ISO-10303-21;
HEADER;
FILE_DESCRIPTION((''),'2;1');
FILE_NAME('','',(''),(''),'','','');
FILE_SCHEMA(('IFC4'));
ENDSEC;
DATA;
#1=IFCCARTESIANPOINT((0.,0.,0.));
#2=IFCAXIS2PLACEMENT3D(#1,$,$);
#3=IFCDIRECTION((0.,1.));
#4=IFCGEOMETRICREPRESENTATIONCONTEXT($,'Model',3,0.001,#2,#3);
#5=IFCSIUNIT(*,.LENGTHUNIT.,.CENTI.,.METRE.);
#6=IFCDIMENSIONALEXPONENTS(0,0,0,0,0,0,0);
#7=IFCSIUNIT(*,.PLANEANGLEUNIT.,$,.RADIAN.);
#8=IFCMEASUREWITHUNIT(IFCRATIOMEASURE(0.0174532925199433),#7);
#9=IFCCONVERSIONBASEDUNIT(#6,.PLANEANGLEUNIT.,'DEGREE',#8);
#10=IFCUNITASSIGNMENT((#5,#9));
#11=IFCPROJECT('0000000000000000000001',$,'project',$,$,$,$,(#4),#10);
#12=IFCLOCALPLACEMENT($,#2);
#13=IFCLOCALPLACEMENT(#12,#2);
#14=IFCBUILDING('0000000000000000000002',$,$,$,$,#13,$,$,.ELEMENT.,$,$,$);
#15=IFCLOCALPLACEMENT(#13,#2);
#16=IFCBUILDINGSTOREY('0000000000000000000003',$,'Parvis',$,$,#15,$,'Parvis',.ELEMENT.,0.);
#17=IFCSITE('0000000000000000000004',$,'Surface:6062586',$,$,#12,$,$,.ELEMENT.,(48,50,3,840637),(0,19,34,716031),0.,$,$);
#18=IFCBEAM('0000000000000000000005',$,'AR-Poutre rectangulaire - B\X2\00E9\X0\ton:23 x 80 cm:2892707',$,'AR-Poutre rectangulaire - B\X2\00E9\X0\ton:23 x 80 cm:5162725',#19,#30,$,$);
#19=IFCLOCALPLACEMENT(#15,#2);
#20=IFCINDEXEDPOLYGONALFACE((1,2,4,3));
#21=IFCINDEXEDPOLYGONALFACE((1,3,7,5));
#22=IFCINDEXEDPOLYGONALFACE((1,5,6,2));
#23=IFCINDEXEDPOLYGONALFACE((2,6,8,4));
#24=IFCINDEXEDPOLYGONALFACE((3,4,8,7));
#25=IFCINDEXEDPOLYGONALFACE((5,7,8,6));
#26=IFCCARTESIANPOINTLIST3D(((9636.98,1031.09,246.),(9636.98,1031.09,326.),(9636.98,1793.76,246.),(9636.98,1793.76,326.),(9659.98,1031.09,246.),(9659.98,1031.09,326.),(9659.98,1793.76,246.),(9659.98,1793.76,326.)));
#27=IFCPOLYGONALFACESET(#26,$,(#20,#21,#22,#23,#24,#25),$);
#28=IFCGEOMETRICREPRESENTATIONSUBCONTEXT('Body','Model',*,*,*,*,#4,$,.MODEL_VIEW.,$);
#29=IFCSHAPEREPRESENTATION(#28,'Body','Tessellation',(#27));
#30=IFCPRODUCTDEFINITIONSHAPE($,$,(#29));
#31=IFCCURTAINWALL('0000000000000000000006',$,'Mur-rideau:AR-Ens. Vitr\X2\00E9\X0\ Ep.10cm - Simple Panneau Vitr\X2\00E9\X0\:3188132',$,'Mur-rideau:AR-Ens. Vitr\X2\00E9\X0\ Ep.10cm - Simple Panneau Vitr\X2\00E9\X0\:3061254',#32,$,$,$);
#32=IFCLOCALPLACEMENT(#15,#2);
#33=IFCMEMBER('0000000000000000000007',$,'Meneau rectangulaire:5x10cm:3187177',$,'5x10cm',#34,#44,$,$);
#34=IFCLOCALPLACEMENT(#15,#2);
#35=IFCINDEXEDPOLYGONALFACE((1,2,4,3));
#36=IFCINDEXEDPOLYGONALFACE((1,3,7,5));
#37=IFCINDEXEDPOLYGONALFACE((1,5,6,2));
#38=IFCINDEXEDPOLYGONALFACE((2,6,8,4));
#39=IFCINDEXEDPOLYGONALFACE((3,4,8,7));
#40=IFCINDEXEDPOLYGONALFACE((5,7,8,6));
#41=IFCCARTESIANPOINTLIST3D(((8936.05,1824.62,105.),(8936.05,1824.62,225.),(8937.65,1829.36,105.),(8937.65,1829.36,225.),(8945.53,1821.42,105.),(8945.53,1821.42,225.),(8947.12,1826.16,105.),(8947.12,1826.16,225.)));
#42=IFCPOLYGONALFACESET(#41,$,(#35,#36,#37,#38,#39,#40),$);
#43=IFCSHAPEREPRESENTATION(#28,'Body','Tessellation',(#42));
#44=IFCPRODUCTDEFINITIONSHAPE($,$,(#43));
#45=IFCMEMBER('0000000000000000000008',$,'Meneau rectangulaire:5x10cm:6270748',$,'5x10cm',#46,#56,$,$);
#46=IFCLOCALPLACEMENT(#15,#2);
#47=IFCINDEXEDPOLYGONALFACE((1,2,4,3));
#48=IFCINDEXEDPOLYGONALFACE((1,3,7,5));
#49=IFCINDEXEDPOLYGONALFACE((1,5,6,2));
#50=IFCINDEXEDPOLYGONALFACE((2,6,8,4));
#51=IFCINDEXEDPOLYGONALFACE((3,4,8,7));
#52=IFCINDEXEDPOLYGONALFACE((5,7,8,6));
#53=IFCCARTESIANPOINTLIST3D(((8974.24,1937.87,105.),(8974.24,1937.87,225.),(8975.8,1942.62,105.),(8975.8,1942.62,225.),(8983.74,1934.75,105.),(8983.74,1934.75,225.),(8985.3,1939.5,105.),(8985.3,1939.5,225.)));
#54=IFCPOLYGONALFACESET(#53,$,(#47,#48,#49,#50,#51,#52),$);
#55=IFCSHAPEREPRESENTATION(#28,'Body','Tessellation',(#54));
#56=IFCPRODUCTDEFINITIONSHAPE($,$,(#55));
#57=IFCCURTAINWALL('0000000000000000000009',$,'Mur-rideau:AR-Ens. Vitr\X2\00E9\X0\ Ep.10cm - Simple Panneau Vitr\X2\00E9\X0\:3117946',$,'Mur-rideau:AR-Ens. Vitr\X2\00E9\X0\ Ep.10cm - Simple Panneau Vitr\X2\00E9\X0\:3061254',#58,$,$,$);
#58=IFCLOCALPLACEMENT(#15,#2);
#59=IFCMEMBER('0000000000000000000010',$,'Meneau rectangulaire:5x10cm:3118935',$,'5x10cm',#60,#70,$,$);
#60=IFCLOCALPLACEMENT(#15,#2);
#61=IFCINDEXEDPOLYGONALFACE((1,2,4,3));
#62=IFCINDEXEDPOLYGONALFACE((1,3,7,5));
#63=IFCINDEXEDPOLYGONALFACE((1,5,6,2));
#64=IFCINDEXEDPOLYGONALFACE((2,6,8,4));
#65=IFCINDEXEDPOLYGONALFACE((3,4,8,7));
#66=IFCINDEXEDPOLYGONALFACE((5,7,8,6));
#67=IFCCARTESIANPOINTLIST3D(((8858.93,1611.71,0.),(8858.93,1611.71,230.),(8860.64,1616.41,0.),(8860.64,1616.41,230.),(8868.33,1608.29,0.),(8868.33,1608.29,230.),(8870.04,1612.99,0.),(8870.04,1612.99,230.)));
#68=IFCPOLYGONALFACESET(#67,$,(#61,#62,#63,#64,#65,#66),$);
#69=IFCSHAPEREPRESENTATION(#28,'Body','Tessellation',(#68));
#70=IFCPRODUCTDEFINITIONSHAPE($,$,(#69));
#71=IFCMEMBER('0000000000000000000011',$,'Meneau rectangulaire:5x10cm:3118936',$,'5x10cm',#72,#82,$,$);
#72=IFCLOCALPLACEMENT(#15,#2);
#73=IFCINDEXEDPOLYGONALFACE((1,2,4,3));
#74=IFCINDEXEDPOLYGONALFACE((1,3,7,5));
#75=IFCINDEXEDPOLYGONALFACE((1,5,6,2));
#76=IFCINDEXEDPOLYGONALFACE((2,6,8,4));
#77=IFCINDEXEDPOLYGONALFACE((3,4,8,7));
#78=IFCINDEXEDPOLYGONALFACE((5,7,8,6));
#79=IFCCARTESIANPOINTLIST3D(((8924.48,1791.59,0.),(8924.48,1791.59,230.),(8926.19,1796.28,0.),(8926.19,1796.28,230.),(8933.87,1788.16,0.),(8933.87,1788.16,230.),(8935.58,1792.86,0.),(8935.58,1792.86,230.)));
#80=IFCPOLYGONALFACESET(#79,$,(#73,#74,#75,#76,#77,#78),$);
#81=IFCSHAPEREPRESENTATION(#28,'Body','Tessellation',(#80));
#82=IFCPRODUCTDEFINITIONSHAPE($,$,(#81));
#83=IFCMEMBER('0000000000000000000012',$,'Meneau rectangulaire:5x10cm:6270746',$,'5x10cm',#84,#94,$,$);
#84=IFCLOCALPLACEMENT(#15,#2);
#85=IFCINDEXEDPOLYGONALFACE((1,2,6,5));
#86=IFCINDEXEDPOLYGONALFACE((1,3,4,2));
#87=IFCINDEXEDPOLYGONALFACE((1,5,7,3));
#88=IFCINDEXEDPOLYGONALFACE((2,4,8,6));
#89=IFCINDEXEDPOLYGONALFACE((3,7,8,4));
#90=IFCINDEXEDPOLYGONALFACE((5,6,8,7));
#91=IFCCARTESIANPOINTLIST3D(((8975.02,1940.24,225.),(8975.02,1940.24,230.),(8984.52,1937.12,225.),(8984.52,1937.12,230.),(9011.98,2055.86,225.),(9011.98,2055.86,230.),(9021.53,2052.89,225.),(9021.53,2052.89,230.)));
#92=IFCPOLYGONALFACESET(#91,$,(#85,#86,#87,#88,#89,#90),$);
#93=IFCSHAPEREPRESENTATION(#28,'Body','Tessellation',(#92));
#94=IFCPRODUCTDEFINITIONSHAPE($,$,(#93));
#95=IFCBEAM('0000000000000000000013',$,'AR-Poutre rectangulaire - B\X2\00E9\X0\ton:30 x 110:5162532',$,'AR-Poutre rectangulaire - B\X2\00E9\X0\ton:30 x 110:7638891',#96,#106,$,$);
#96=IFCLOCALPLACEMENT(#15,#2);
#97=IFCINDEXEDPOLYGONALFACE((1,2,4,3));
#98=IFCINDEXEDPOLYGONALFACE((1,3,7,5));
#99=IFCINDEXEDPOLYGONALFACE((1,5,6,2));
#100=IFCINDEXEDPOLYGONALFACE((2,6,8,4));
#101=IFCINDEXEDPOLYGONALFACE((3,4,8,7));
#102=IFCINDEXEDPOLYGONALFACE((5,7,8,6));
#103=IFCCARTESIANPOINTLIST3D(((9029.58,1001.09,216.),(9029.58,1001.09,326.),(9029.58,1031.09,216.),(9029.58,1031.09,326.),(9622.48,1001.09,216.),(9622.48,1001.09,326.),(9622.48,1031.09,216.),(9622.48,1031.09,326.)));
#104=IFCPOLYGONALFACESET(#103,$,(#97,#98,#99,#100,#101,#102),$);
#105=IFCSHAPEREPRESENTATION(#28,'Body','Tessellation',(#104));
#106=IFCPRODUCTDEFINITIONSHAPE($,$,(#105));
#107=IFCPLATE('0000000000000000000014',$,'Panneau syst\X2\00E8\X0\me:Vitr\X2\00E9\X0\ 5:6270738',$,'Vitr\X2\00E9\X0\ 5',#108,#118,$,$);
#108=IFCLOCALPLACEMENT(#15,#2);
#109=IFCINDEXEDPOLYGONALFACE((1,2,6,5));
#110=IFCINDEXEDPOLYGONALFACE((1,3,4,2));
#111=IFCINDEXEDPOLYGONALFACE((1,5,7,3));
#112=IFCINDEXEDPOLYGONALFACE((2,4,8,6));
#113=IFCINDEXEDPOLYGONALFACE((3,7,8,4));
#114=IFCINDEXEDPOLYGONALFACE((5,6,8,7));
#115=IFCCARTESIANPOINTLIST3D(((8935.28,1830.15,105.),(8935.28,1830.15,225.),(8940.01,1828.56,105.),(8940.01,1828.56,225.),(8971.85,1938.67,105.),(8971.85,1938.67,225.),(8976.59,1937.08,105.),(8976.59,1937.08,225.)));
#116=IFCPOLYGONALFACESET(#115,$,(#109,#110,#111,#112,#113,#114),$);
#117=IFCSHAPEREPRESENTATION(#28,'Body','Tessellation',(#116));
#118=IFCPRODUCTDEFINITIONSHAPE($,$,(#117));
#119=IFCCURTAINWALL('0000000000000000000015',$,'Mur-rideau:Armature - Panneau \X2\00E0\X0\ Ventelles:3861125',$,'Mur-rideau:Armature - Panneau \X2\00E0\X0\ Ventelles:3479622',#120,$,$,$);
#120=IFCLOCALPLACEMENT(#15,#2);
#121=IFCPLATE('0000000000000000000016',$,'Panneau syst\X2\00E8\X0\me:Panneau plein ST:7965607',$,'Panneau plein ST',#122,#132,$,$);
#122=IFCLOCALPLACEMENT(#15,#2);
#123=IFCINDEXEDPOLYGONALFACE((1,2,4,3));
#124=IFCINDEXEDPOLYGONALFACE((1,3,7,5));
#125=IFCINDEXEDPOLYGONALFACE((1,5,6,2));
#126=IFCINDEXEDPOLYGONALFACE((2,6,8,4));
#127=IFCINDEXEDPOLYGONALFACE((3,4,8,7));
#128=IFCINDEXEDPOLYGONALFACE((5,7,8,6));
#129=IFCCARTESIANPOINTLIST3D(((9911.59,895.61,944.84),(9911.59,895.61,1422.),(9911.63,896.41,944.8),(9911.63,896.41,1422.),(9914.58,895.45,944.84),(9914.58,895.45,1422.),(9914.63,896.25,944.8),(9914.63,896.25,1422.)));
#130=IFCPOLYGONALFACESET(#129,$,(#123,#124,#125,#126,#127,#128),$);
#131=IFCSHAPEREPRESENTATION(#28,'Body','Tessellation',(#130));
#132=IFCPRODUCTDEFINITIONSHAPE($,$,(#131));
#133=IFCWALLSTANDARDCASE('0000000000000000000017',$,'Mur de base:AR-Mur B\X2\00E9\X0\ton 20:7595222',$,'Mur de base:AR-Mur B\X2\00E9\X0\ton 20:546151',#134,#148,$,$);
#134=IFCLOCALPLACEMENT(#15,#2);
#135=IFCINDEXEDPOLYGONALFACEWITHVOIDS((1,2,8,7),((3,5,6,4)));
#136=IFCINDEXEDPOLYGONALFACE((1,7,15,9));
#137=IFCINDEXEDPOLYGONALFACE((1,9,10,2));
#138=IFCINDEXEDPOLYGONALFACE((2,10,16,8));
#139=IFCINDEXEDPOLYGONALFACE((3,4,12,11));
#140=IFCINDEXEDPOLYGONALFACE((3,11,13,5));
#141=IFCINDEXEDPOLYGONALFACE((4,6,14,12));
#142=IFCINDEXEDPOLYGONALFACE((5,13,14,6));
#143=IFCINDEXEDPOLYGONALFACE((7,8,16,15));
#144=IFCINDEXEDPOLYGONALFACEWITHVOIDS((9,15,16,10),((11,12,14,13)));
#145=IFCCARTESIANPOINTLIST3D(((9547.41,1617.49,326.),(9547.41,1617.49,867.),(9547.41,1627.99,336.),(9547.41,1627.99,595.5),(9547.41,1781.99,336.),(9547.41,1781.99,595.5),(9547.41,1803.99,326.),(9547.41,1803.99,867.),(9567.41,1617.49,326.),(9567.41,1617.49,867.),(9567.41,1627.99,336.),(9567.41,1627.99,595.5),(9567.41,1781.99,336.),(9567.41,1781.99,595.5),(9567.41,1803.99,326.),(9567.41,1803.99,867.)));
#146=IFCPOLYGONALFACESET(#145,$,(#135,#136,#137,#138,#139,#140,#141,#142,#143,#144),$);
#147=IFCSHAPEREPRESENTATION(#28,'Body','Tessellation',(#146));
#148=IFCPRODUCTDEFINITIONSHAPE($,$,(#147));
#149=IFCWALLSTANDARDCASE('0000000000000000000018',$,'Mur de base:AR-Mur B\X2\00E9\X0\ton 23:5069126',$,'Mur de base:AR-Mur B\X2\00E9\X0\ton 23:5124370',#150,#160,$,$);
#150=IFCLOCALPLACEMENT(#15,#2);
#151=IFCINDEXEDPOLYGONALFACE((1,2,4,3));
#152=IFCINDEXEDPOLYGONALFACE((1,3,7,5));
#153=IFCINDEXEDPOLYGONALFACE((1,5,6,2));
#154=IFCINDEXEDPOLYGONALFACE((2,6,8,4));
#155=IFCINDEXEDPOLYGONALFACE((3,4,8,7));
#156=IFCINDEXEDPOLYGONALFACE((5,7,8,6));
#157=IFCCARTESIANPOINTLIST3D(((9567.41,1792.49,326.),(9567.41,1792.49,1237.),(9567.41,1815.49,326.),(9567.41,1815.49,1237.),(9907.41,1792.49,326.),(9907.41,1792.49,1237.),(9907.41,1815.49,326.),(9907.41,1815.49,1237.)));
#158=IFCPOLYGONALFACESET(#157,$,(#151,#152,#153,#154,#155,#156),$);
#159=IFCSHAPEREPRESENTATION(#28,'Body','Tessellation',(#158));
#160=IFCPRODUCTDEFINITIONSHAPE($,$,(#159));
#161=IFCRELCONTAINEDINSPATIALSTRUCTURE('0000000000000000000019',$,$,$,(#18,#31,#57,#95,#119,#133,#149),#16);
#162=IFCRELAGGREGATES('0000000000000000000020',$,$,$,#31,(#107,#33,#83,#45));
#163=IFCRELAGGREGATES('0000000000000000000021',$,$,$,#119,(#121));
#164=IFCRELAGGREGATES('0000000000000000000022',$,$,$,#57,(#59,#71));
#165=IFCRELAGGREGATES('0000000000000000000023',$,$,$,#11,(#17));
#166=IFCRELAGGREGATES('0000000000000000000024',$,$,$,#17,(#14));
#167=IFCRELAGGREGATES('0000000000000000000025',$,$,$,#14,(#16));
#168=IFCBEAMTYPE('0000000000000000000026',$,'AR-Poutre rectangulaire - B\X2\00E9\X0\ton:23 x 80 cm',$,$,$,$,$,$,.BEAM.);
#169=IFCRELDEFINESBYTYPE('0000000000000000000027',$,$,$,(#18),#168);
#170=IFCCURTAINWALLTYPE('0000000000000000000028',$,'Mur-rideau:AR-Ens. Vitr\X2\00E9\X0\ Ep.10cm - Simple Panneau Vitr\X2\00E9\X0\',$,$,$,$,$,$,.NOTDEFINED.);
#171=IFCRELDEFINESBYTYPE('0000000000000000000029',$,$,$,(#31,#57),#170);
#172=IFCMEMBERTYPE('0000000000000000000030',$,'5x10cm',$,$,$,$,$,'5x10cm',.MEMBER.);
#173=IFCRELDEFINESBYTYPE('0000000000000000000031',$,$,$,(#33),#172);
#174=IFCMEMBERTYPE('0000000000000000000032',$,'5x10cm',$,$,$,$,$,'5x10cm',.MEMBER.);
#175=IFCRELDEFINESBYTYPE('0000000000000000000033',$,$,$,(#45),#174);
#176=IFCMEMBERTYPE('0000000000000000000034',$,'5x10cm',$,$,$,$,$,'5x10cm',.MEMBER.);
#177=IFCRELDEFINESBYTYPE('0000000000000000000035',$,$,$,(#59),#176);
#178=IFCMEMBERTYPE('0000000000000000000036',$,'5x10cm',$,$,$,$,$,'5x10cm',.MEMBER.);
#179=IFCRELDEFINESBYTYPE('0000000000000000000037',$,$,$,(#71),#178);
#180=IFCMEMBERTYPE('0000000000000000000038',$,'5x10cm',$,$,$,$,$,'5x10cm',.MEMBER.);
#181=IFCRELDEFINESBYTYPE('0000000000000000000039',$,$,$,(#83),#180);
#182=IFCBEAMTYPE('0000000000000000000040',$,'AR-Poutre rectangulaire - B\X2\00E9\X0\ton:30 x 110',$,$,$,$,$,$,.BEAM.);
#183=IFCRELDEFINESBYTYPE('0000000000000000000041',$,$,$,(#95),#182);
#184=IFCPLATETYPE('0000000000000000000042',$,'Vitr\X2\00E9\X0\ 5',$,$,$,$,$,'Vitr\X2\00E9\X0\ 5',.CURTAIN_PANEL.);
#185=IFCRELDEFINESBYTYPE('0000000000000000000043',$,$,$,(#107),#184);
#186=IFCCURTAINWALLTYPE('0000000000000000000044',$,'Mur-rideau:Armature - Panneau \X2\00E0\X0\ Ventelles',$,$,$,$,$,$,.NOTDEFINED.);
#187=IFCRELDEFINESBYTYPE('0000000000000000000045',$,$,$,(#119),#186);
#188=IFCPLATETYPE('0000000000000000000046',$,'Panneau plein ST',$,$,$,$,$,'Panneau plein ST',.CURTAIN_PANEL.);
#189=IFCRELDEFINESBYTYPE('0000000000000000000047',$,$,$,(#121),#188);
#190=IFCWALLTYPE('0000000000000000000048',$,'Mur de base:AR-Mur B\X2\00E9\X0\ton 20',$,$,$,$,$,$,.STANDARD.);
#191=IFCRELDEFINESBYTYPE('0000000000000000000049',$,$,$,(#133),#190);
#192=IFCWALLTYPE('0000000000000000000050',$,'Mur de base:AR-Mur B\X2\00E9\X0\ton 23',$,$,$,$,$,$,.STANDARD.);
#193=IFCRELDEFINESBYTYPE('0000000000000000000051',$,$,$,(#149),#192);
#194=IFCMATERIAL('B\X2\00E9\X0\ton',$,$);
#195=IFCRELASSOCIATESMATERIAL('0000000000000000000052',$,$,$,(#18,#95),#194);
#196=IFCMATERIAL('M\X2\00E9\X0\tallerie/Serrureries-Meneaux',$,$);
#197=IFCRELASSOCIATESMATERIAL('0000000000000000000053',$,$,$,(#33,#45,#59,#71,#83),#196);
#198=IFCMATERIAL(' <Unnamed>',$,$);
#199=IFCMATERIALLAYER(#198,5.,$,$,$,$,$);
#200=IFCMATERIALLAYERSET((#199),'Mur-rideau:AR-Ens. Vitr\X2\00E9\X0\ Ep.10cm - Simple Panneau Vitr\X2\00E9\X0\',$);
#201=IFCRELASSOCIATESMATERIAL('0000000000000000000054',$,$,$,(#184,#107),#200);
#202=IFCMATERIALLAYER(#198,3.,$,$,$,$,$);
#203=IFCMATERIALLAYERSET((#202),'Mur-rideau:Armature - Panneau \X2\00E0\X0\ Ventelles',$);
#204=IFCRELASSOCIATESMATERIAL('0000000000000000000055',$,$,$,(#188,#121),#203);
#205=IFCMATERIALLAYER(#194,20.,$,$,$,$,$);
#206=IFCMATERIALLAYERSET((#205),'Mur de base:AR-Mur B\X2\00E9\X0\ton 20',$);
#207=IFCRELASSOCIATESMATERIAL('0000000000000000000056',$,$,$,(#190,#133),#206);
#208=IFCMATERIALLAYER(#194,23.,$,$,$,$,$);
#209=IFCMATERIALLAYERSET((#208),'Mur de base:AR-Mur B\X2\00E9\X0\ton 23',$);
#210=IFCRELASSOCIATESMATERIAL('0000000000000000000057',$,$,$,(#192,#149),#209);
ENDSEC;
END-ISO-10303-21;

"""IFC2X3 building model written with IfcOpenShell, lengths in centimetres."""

from ifc_helpers import new_model, entity, si_unit, converted_unit, direction, frame, frame_2d, origin, origin_2d_with_axis, place, context, subcontext, project, spatial, polyline, rectangle, outline, extrude, clip, halfspace, bounded_halfspace, source, transform, mapped, material, layer, layer_set, layer_usage, type_object, type_shapes, element, aggregate, save


model = new_model("IFC2X3")

# Units and contexts
model_context = context("Model", 3, precision=0.001, world=origin(), true_north=direction((0.0, 1.0)))
body_context = subcontext(model_context, "Body", "Model", "MODEL_VIEW")
ifc_project = project(units=[si_unit("LENGTHUNIT", "METRE", prefix="CENTI"), converted_unit("PLANEANGLEUNIT", "DEGREE", entity("IfcRatioMeasure", 0.0174532925199433), si_unit("PLANEANGLEUNIT", "RADIAN"), dimensions=[0, 0, 0, 0, 0, 0, 0])], contexts=[model_context])

# Site, building, storey
site_placement = place(None, origin())
site = spatial("IfcSite", under=ifc_project, at=site_placement, Name="Surface:6062586", CompositionType="ELEMENT", RefLatitude=(48, 50, 3, 840637), RefLongitude=(0, 19, 34, 716031), RefElevation=0.0)
building_placement = place(site_placement, origin())
building = spatial("IfcBuilding", under=site, at=building_placement, CompositionType="ELEMENT")
storey_placement = place(building_placement, frame((0.0, 0.0, 0.0)))
storey = spatial("IfcBuildingStorey", under=building, at=storey_placement, Name="Parvis", LongName="Parvis", CompositionType="ELEMENT", Elevation=0.0)

# Beam
ifc_material_1 = material(Name="Béton")
beam_type_1 = type_object("IfcBeamType", Name="AR-Poutre rectangulaire - Béton:23 x 80 cm", PredefinedType="BEAM")
beam_1_placement = place(storey_placement, frame((9648.48, 1792.49, 326.0), z_axis=(0.0, 0.0, 1.0), x_axis=(0.0, -1.0, 0.0)))
element("IfcBeam", 1, at=beam_1_placement, inside=storey, type_object=beam_type_1, material=ifc_material_1, Name="AR-Poutre rectangulaire - Béton:23 x 80 cm:2892707", ObjectType="AR-Poutre rectangulaire - Béton:23 x 80 cm:5162725", context=body_context, shape_type="SweptSolid", body=[
    extrude(rectangle(XDim=80.0, YDim=23.0, at=frame_2d((0.0, 0.0), x_axis=(1.0, 0.0))), frame((-1.27, 0.0, -40.0), z_axis=(1.0, 0.0, 0.0), x_axis=(0.0, 0.0, -1.0)), (0.0, 0.0, 1.0), 762.67),
])

# Curtain walls, members
curtain_wall_type_1 = type_object("IfcCurtainWallType", Name="Mur-rideau:AR-Ens. Vitré Ep.10cm - Simple Panneau Vitré", PredefinedType="NOTDEFINED")
curtain_wall_1_placement = place(storey_placement, frame((0.0, 0.0, 0.0)))
curtain_wall_1 = element("IfcCurtainWall", 2, at=curtain_wall_1_placement, inside=storey, type_object=curtain_wall_type_1, Name="Mur-rideau:AR-Ens. Vitré Ep.10cm - Simple Panneau Vitré:3188132", ObjectType="Mur-rideau:AR-Ens. Vitré Ep.10cm - Simple Panneau Vitré:3061254")
ifc_material_2 = material(Name="Métallerie/Serrureries-Meneaux")
member_type_1 = type_object("IfcMemberType", Name="5x10cm", ElementType="5x10cm", PredefinedType="MEMBER")
shared_shape_1 = source(origin(), body_context, "Body", "SweptSolid", [
    extrude(rectangle(XDim=10.0, YDim=5.0, at=origin_2d_with_axis()), frame((-2.5, -5.0, -120.0), z_axis=(0.0, 0.0, 1.0), x_axis=(0.0, -1.0, 0.0)), (0.0, 0.0, 1.0), 120.0),
])
type_shapes(member_type_1, [shared_shape_1])
member_1_placement = place(storey_placement, frame((8936.05, 1824.62, 105.0), z_axis=(0.0, 0.0, -1.0), x_axis=(-0.319392, -0.947623, 0.0)))
member_1 = element("IfcMember", 3, at=member_1_placement, type_object=member_type_1, material=ifc_material_2, Name="Meneau rectangulaire:5x10cm:3187177", ObjectType="5x10cm", context=body_context, shape_type="MappedRepresentation", body=[
    mapped(shared_shape_1, transform((0.0, 0.0, 0.0), scale=1.0)),
])
member_type_2 = type_object("IfcMemberType", Name="5x10cm", ElementType="5x10cm", PredefinedType="MEMBER")
shared_shape_2 = source(origin(), body_context, "Body", "SweptSolid", [
    extrude(rectangle(XDim=10.0, YDim=5.0, at=origin_2d_with_axis()), frame((0.0, -5.0, -120.0), z_axis=(0.0, 0.0, 1.0), x_axis=(0.0, -1.0, 0.0)), (0.0, 0.0, 1.0), 120.0),
])
type_shapes(member_type_2, [shared_shape_2])
member_2_placement = place(storey_placement, frame((8975.02, 1940.24, 105.0), z_axis=(0.0, 0.0, -1.0), x_axis=(-0.31194, -0.950102, 0.0)))
member_2 = element("IfcMember", 4, at=member_2_placement, type_object=member_type_2, material=ifc_material_2, Name="Meneau rectangulaire:5x10cm:6270748", ObjectType="5x10cm", context=body_context, shape_type="MappedRepresentation", body=[
    mapped(shared_shape_2, transform((0.0, 0.0, 0.0), scale=1.0)),
])
curtain_wall_2_placement = place(storey_placement, frame((0.0, 0.0, 0.0)))
curtain_wall_2 = element("IfcCurtainWall", 5, at=curtain_wall_2_placement, inside=storey, type_object=curtain_wall_type_1, Name="Mur-rideau:AR-Ens. Vitré Ep.10cm - Simple Panneau Vitré:3117946", ObjectType="Mur-rideau:AR-Ens. Vitré Ep.10cm - Simple Panneau Vitré:3061254")
member_type_3 = type_object("IfcMemberType", Name="5x10cm", ElementType="5x10cm", PredefinedType="MEMBER")
shared_shape_3 = source(origin(), body_context, "Body", "SweptSolid", [
    extrude(rectangle(XDim=10.0, YDim=5.0, at=origin_2d_with_axis()), frame((-2.5, -5.0, -230.0), z_axis=(0.0, 0.0, 1.0), x_axis=(0.0, -1.0, 0.0)), (0.0, 0.0, 1.0), 230.0),
])
type_shapes(member_type_3, [shared_shape_3])
member_3_placement = place(storey_placement, frame((8858.93, 1611.71, 0.0), z_axis=(0.0, 0.0, -1.0), x_axis=(-0.34238, -0.939562, 0.0)))
member_3 = element("IfcMember", 6, at=member_3_placement, type_object=member_type_3, material=ifc_material_2, Name="Meneau rectangulaire:5x10cm:3118935", ObjectType="5x10cm", context=body_context, shape_type="MappedRepresentation", body=[
    mapped(shared_shape_3, transform((0.0, 0.0, 0.0), scale=1.0)),
])
member_type_4 = type_object("IfcMemberType", Name="5x10cm", ElementType="5x10cm", PredefinedType="MEMBER")
shared_shape_4 = source(origin(), body_context, "Body", "SweptSolid", [
    extrude(rectangle(XDim=10.0, YDim=5.0, at=origin_2d_with_axis()), frame((-2.5, -5.0, -230.0), z_axis=(0.0, 0.0, 1.0), x_axis=(0.0, -1.0, 0.0)), (0.0, 0.0, 1.0), 230.0),
])
type_shapes(member_type_4, [shared_shape_4])
member_4_placement = place(storey_placement, frame((8926.19, 1796.28, 230.0), z_axis=(0.0, 0.0, 1.0), x_axis=(0.34238, 0.939562, 0.0)))
member_4 = element("IfcMember", 7, at=member_4_placement, type_object=member_type_4, material=ifc_material_2, Name="Meneau rectangulaire:5x10cm:3118936", ObjectType="5x10cm", context=body_context, shape_type="MappedRepresentation", body=[
    mapped(shared_shape_4, transform((0.0, 0.0, 0.0), scale=1.0)),
])

# Member
member_type_5 = type_object("IfcMemberType", Name="5x10cm", ElementType="5x10cm", PredefinedType="MEMBER")
shared_shape_5 = source(origin(), body_context, "Body", "Clipping", [
    clip(clip(extrude(rectangle(XDim=10.0, YDim=5.0, at=frame_2d((0.0, 0.0), x_axis=(1.0, 0.0))), frame((-2.5, -5.0, -121.46), z_axis=(0.0, 0.0, 1.0), x_axis=(0.0, -1.0, 0.0)), (0.0, 0.0, 1.0), 121.54), halfspace(frame((-30.48, 0.0, -121.38), z_axis=(0.0, 0.007833, -0.999969), x_axis=(1.0, 0.0, 0.0)), False)), halfspace(frame((-30.48, 0.0, 0.0), z_axis=(0.0, 0.007833, 0.999969), x_axis=(1.0, 0.0, 0.0)), False)),
])
type_shapes(member_type_5, [shared_shape_5])
member_5_placement = place(storey_placement, frame((8975.02, 1940.24, 230.0), z_axis=(-0.304508, -0.95251, 0.0), x_axis=(0.0, 0.0, 1.0)))
member_5 = element("IfcMember", 8, at=member_5_placement, type_object=member_type_5, material=ifc_material_2, Name="Meneau rectangulaire:5x10cm:6270746", ObjectType="5x10cm", context=body_context, shape_type="MappedRepresentation", body=[
    mapped(shared_shape_5, transform((0.0, 0.0, 0.0), scale=1.0)),
])

# Beam
beam_type_2 = type_object("IfcBeamType", Name="AR-Poutre rectangulaire - Béton:30 x 110", PredefinedType="BEAM")
beam_2_placement = place(storey_placement, frame((9030.82, 1016.09, 326.0)))
element("IfcBeam", 9, at=beam_2_placement, inside=storey, type_object=beam_type_2, material=ifc_material_1, Name="AR-Poutre rectangulaire - Béton:30 x 110:5162532", ObjectType="AR-Poutre rectangulaire - Béton:30 x 110:7638891", context=body_context, shape_type="SweptSolid", body=[
    extrude(rectangle(XDim=110.0, YDim=30.0, at=frame_2d((0.0, 0.0), x_axis=(1.0, 0.0))), frame((-1.24, 0.0, -55.0), z_axis=(1.0, 0.0, 0.0), x_axis=(0.0, 0.0, -1.0)), (0.0, 0.0, 1.0), 592.9),
])

# Plate
ifc_material_3 = material(Name=" <Unnamed>")
ifc_layer_1 = layer(ifc_material_3, 5.0)
ifc_layer_set_1 = layer_set([ifc_layer_1], Name="Mur-rideau:AR-Ens. Vitré Ep.10cm - Simple Panneau Vitré")
ifc_layer_usage_1 = layer_usage(ifc_layer_set_1, "AXIS3", "POSITIVE", 0.0)
plate_type_1 = type_object("IfcPlateType", Name="Vitré 5", ElementType="Vitré 5", PredefinedType="CURTAIN_PANEL", material=ifc_layer_set_1)
shared_shape_6 = source(origin(), body_context, "Body", "SweptSolid", [
    extrude(rectangle(XDim=5.0, YDim=114.52, at=frame_2d((0.0, 0.0), x_axis=(1.0, 0.0))), frame((0.0, 0.0, 0.0), z_axis=(0.0, 0.0, 1.0), x_axis=(0.0, 1.0, 0.0)), (0.0, 0.0, 1.0), 120.0),
])
type_shapes(plate_type_1, [shared_shape_6])
plate_1_placement = place(curtain_wall_1_placement, frame((8955.93, 1883.62, 105.0), z_axis=(0.0, 0.0, 1.0), x_axis=(-0.319392, -0.947623, 0.0)))
plate_1 = element("IfcPlate", 10, at=plate_1_placement, type_object=plate_type_1, material=ifc_layer_usage_1, Name="Panneau système:Vitré 5:6270738", ObjectType="Vitré 5", context=body_context, shape_type="MappedRepresentation", body=[
    mapped(shared_shape_6, transform((0.0, 0.0, 0.0), scale=1.0)),
])
aggregate(curtain_wall_1, [plate_1, member_1, member_5, member_2])

# Curtain wall, plate
curtain_wall_type_2 = type_object("IfcCurtainWallType", Name="Mur-rideau:Armature - Panneau à Ventelles", PredefinedType="NOTDEFINED")
curtain_wall_3_placement = place(storey_placement, frame((0.0, 0.0, 0.0)))
curtain_wall_3 = element("IfcCurtainWall", 11, at=curtain_wall_3_placement, inside=storey, type_object=curtain_wall_type_2, Name="Mur-rideau:Armature - Panneau à Ventelles:3861125", ObjectType="Mur-rideau:Armature - Panneau à Ventelles:3479622")
ifc_layer_2 = layer(ifc_material_3, 3.0)
ifc_layer_set_2 = layer_set([ifc_layer_2], Name="Mur-rideau:Armature - Panneau à Ventelles")
ifc_layer_usage_2 = layer_usage(ifc_layer_set_2, "AXIS3", "POSITIVE", 0.05)
plate_type_2 = type_object("IfcPlateType", Name="Panneau plein ST", ElementType="Panneau plein ST", PredefinedType="CURTAIN_PANEL", material=ifc_layer_set_2)
shared_shape_7 = source(origin(), body_context, "Body", "SweptSolid", [
    extrude(outline(polyline([(-238.61, -0.4), (238.59, -0.4), (238.59, 0.4), (-238.57, 0.4), (-238.61, -0.4)])), frame((0.0, 0.0, 238.61), z_axis=(0.0, 1.0, 0.0), x_axis=(0.0, 0.0, 1.0)), (0.0, 0.0, 1.0), 3.0),
])
type_shapes(plate_type_2, [shared_shape_7])
plate_2_placement = place(curtain_wall_3_placement, frame((9911.61, 896.01, 944.8), z_axis=(0.0, 0.0, 1.0), x_axis=(-0.053019, -0.998593, 0.0)))
plate_2 = element("IfcPlate", 12, at=plate_2_placement, type_object=plate_type_2, material=ifc_layer_usage_2, Name="Panneau système:Panneau plein ST:7965607", ObjectType="Panneau plein ST", context=body_context, shape_type="MappedRepresentation", body=[
    mapped(shared_shape_7, transform((0.0, 0.0, 0.0), scale=1.0)),
])
aggregate(curtain_wall_3, [plate_2])

# Wall, opening
ifc_layer_3 = layer(ifc_material_1, 20.0)
ifc_layer_set_3 = layer_set([ifc_layer_3], Name="Mur de base:AR-Mur Béton 20")
ifc_layer_usage_3 = layer_usage(ifc_layer_set_3, "AXIS2", "NEGATIVE", 10.0)
wall_type_1 = type_object("IfcWallType", Name="Mur de base:AR-Mur Béton 20", PredefinedType="STANDARD", material=ifc_layer_set_3)
wall_1_placement = place(storey_placement, frame((9557.41, 1803.99, 326.0), z_axis=(0.0, 0.0, 1.0), x_axis=(0.0, -1.0, 0.0)))
wall_1 = element("IfcWallStandardCase", 13, at=wall_1_placement, inside=storey, type_object=wall_type_1, material=ifc_layer_usage_3, Name="Mur de base:AR-Mur Béton 20:7595222", ObjectType="Mur de base:AR-Mur Béton 20:546151", context=body_context, shape_type="SweptSolid", body=[
    extrude(rectangle(XDim=186.5, YDim=20.0, at=frame_2d((93.25, 0.0), x_axis=(-1.0, 0.0))), origin(), (0.0, 0.0, 1.0), 541.0),
])
opening_1_placement = place(wall_1_placement, frame((176.0, 10.0, 10.0)))
element("IfcOpeningElement", 14, at=opening_1_placement, cuts=wall_1, ObjectType="Opening", context=body_context, shape_type="SweptSolid", body=[
    extrude(rectangle(XDim=259.5, YDim=154.0, at=frame_2d((129.75, 77.0), x_axis=(1.0, 0.0))), frame((0.0, 0.0, 0.0), z_axis=(0.0, -1.0, 0.0), x_axis=(0.0, 0.0, 1.0)), (0.0, 0.0, 1.0), 20.0),
])

# Wall
ifc_layer_4 = layer(ifc_material_1, 23.0)
ifc_layer_set_4 = layer_set([ifc_layer_4], Name="Mur de base:AR-Mur Béton 23")
ifc_layer_usage_4 = layer_usage(ifc_layer_set_4, "AXIS2", "NEGATIVE", 11.5)
wall_type_2 = type_object("IfcWallType", Name="Mur de base:AR-Mur Béton 23", PredefinedType="STANDARD", material=ifc_layer_set_4)
wall_2_placement = place(storey_placement, frame((9567.41, 1803.99, 326.0)))
element("IfcWallStandardCase", 15, at=wall_2_placement, inside=storey, type_object=wall_type_2, material=ifc_layer_usage_4, Name="Mur de base:AR-Mur Béton 23:5069126", ObjectType="Mur de base:AR-Mur Béton 23:5124370", context=body_context, shape_type="Clipping", body=[
    clip(extrude(rectangle(XDim=340.0, YDim=23.0, at=frame_2d((170.0, 0.0), x_axis=(-1.0, 0.0))), origin(), (0.0, 0.0, 1.0), 911.0), bounded_halfspace(frame((0.0, -11.5, 911.0), z_axis=(0.0, 0.0, -1.0), x_axis=(-1.0, 0.0, 0.0)), True, frame((0.0, -11.5, 911.0)), polyline([(0.0, 0.0), (341.73, 0.0), (342.95, 23.0), (0.0, 23.0), (0.0, 0.0)]))),
])

aggregate(curtain_wall_2, [member_3, member_4])

save(model, "model.ifc")
